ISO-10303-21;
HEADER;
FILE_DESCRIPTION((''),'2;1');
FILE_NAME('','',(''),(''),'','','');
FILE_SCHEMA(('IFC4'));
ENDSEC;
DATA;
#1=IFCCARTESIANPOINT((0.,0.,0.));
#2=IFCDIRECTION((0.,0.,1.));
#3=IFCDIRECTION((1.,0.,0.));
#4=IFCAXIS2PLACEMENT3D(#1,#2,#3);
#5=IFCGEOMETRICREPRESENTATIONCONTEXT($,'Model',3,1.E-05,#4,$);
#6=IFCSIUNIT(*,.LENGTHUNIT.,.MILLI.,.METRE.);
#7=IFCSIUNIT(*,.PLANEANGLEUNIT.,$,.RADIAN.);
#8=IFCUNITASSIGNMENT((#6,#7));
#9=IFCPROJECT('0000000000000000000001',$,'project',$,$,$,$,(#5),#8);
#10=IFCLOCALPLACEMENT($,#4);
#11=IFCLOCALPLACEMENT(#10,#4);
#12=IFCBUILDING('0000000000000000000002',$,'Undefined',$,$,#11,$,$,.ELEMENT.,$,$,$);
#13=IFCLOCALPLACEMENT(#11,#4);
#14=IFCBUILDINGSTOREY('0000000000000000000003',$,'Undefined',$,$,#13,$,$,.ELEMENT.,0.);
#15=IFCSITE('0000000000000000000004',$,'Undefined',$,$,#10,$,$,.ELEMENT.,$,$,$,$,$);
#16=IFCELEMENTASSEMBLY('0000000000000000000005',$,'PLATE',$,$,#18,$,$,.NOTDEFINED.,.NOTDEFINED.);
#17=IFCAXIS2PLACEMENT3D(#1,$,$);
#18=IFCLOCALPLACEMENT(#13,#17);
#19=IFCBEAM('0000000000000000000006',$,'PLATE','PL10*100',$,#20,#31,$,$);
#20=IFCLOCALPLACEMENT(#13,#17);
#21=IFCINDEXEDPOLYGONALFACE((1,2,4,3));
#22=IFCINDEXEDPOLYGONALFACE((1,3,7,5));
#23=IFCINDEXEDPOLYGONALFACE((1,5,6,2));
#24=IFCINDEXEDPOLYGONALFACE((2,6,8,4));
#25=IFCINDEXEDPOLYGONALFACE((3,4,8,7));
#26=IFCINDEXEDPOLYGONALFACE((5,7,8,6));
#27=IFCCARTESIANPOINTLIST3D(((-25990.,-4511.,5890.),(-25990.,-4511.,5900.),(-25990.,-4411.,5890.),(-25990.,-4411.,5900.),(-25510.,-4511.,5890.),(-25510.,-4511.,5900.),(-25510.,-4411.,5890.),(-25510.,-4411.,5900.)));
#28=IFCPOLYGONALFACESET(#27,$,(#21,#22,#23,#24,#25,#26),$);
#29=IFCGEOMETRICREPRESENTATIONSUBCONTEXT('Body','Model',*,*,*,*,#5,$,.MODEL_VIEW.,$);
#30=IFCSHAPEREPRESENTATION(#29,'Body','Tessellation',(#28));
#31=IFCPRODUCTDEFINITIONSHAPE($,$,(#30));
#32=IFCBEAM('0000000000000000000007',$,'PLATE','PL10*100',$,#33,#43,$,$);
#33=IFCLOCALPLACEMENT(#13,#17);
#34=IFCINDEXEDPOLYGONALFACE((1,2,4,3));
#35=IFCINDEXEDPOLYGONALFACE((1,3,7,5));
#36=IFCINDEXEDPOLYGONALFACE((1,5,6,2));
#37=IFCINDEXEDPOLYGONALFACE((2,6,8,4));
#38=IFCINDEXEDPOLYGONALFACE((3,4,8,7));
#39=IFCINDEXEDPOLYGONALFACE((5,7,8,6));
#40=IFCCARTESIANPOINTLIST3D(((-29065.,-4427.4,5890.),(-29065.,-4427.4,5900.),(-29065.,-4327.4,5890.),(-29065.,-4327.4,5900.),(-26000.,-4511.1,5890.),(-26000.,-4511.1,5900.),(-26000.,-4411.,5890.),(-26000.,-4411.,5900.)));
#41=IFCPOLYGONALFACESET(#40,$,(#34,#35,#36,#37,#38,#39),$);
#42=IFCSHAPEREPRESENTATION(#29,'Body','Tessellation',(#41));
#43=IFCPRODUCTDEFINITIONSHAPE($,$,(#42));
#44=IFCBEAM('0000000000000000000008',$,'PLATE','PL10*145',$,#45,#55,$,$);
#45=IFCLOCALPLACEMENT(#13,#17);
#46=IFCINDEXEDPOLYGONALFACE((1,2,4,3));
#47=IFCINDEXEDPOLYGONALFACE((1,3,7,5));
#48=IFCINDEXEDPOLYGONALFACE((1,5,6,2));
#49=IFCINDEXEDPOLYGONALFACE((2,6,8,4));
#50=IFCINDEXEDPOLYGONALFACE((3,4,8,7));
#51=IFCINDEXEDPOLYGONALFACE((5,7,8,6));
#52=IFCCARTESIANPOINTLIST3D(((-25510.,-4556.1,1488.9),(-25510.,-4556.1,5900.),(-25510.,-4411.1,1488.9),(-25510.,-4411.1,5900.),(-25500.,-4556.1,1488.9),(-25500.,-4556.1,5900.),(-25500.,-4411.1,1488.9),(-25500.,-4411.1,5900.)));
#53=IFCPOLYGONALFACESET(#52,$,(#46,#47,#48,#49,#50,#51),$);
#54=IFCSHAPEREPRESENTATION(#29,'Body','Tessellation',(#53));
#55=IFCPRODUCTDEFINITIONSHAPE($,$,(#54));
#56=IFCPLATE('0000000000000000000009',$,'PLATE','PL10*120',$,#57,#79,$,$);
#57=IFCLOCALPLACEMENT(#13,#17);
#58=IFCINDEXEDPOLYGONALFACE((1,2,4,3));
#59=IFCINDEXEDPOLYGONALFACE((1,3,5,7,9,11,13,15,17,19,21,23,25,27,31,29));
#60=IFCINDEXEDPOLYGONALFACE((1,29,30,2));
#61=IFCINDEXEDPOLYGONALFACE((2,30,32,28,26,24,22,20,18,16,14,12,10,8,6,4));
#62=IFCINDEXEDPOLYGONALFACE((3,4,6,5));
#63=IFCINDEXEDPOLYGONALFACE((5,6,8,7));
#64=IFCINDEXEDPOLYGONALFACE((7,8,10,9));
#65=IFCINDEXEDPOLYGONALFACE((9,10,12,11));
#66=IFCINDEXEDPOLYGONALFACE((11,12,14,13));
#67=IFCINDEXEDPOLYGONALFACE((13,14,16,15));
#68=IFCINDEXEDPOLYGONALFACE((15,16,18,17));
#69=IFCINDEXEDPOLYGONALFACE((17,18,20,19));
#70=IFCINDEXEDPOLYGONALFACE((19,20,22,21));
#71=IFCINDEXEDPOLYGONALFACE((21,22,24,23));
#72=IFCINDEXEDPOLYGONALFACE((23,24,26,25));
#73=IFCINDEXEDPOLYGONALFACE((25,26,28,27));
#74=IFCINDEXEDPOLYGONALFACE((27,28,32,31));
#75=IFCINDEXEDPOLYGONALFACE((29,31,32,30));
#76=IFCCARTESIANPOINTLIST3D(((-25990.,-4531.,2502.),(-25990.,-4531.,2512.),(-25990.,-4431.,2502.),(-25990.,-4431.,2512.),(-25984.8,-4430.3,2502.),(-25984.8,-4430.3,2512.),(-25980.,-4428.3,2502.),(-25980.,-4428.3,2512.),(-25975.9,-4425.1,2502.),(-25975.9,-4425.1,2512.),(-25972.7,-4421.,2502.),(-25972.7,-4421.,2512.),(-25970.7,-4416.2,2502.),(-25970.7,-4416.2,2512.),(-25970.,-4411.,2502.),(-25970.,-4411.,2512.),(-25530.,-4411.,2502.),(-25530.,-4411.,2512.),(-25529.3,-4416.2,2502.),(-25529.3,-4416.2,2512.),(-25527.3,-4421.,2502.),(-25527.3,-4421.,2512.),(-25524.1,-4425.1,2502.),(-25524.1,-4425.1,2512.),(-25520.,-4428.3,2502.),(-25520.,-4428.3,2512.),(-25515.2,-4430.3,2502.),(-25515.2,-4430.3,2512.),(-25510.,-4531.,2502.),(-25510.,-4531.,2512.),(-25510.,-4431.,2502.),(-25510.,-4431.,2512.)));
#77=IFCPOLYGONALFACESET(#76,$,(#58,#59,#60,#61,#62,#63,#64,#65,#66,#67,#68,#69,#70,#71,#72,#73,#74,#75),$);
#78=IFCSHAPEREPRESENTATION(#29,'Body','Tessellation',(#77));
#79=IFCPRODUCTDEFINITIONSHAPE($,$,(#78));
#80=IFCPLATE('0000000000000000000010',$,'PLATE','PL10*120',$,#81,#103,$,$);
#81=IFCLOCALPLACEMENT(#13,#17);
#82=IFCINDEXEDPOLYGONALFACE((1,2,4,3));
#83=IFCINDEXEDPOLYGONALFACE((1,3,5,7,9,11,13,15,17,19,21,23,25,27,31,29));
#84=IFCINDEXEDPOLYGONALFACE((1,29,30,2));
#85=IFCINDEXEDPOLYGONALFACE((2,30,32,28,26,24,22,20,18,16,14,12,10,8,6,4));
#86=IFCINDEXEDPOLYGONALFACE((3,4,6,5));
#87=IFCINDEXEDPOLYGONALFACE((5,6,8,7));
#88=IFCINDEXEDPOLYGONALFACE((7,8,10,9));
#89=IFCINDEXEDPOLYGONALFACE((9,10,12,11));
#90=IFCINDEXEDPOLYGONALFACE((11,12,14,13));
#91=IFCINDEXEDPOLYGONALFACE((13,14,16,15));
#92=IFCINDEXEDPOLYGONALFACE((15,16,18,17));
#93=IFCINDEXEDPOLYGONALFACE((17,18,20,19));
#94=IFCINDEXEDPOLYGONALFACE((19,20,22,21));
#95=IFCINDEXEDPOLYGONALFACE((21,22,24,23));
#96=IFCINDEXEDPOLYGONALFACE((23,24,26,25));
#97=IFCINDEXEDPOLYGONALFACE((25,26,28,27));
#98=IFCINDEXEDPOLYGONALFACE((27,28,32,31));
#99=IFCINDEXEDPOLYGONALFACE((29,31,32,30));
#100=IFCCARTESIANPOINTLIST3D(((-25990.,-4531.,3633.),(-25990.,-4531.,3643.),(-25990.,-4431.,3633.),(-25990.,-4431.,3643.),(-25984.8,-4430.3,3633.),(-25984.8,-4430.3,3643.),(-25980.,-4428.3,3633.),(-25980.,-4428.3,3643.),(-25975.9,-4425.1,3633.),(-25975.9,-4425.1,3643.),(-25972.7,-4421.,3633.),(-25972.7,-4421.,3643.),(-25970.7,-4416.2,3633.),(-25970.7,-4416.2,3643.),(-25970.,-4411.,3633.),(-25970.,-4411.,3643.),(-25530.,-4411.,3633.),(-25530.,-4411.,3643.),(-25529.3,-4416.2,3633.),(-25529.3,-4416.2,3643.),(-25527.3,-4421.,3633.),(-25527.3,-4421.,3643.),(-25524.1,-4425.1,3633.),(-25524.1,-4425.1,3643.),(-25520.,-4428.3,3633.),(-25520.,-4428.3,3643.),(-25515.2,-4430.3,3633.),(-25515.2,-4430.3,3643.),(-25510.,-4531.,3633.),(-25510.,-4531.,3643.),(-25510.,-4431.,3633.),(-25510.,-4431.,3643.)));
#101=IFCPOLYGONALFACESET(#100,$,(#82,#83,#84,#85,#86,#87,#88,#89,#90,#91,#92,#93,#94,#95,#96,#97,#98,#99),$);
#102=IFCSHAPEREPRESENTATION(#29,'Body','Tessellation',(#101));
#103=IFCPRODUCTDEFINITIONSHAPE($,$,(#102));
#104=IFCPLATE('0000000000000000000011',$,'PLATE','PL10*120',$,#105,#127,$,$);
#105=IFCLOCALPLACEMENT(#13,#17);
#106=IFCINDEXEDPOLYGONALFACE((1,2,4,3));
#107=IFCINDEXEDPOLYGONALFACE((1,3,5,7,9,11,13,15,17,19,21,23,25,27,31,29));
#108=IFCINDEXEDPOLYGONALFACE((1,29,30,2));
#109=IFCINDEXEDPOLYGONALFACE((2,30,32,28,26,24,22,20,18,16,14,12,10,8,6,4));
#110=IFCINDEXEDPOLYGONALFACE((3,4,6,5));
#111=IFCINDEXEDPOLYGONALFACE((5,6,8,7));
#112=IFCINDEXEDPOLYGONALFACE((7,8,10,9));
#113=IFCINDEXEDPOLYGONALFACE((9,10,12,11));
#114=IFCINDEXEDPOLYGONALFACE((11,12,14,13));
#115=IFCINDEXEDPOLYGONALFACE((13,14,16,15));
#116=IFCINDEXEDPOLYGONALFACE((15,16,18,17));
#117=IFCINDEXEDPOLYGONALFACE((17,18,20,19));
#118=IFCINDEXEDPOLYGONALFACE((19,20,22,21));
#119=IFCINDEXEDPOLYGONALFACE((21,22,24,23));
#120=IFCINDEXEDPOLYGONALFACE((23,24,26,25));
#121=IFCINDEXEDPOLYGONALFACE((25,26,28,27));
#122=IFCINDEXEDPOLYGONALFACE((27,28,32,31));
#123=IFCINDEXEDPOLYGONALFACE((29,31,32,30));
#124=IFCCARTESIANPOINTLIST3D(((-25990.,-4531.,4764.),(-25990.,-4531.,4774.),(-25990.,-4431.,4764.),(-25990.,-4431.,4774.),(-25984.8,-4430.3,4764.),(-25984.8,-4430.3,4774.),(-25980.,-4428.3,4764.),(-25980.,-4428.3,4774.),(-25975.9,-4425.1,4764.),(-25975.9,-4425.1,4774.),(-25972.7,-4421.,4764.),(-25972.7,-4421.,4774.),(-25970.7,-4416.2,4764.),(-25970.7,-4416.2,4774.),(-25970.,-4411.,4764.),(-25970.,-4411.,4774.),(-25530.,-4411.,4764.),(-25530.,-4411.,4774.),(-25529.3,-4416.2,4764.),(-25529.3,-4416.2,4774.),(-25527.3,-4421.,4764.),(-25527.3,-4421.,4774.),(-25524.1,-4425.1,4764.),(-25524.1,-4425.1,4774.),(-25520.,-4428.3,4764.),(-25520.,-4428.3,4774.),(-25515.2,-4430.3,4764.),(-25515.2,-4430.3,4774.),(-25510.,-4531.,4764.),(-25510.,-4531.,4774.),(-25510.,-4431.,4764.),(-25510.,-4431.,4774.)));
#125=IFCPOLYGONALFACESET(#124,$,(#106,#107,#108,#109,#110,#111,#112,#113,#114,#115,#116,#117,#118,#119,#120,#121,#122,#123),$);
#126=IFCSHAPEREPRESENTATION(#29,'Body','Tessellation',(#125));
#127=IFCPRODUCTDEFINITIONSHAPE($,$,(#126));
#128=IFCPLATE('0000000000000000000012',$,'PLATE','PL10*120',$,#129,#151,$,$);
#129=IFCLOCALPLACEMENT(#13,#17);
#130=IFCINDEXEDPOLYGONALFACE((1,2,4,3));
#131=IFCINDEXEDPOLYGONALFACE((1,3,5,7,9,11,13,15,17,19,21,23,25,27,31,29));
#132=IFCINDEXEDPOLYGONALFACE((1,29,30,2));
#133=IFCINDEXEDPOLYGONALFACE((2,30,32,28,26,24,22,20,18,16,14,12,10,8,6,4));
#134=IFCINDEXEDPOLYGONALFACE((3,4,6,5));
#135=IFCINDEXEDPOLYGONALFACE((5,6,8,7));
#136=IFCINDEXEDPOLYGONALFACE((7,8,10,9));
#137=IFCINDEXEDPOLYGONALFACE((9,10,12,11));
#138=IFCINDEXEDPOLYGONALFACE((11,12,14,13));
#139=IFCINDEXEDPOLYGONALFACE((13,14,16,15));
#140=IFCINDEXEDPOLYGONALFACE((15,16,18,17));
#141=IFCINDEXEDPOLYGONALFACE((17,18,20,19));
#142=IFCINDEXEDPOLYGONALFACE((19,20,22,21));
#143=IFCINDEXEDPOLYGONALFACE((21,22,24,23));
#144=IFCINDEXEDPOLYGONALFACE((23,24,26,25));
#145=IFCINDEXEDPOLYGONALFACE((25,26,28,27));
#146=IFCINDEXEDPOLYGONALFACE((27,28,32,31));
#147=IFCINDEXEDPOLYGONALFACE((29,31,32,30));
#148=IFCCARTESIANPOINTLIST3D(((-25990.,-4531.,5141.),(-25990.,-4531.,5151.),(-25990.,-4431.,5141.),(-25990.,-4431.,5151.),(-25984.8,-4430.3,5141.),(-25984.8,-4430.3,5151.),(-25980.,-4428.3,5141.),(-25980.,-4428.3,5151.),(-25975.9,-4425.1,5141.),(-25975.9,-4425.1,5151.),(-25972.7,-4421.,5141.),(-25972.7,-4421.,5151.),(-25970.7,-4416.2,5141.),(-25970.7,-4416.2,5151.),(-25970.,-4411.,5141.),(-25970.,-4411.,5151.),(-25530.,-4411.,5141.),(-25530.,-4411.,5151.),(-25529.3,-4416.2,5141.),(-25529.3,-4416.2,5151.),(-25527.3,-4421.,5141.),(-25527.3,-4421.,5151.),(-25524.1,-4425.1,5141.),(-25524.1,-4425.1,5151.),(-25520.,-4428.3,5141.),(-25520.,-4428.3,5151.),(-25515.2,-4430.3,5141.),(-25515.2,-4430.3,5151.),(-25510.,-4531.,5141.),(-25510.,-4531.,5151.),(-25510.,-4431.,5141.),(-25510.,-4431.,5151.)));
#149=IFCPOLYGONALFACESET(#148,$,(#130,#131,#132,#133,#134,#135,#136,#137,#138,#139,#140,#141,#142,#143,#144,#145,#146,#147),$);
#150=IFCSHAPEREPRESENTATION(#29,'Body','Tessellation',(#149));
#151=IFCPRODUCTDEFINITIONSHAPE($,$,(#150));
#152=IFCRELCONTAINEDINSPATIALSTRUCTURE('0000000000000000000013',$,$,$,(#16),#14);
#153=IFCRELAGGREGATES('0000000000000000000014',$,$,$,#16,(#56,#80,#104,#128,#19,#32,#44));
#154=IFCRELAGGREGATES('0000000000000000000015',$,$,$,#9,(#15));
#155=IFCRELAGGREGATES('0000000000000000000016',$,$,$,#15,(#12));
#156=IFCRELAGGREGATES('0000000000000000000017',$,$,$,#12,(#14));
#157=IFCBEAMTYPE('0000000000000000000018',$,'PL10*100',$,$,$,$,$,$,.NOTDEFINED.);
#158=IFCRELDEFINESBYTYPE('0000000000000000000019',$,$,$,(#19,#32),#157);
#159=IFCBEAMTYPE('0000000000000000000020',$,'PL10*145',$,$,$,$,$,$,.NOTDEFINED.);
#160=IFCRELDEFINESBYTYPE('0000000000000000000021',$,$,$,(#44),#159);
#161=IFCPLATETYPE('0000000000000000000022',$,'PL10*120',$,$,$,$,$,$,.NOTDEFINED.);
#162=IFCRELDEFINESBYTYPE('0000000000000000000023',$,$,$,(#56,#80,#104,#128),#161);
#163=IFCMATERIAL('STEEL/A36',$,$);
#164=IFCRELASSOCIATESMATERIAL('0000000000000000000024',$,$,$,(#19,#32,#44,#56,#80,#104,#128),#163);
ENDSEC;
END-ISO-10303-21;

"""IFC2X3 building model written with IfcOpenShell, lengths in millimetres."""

from ifc_helpers import new_model, si_unit, frame, frame_2d, origin_with_axes, origin_2d_with_axis, place, context, subcontext, project, spatial, polyline, circle_curve, parameter, trimmed, segment, composite_curve, rectangle, outline, extrude, clip, halfspace, material, type_object, element, aggregate, save


model = new_model("IFC2X3")

# Units and contexts
model_context = context("Model", 3, precision=1e-05, world=origin_with_axes())
body_context = subcontext(model_context, "Body", "Model", "MODEL_VIEW")
ifc_project = project(units=[si_unit("LENGTHUNIT", "METRE", prefix="MILLI"), si_unit("PLANEANGLEUNIT", "RADIAN")], contexts=[model_context])

# Site, building, storey
site_placement = place(None, origin_with_axes())
site = spatial("IfcSite", under=ifc_project, at=site_placement, Name="Undefined", CompositionType="ELEMENT")
building_placement = place(site_placement, origin_with_axes())
building = spatial("IfcBuilding", under=site, at=building_placement, Name="Undefined", CompositionType="ELEMENT")
storey_placement = place(building_placement, origin_with_axes())
storey = spatial("IfcBuildingStorey", under=building, at=storey_placement, Name="Undefined", CompositionType="ELEMENT", Elevation=0.0)

# Element assembly, beams, plates
assembly_1_placement = place(storey_placement, origin_with_axes())
assembly_1 = element("IfcElementAssembly", 1, at=assembly_1_placement, inside=storey, Name="PLATE", AssemblyPlace="NOTDEFINED", PredefinedType="NOTDEFINED")
ifc_material_1 = material(Name="STEEL/A36")
beam_type_1 = type_object("IfcBeamType", Name="PL10*100", PredefinedType="NOTDEFINED")
beam_1_placement = place(assembly_1_placement, frame((-25510.0, -4461.0, 5895.0), z_axis=(-0.000007, -1.0, 0.0), x_axis=(-1.0, 0.000007, 0.0)))
beam_1 = element("IfcBeam", 2, at=beam_1_placement, type_object=beam_type_1, material=ifc_material_1, Name="PLATE", Description="PL10*100", context=body_context, shape_type="SweptSolid", body=[
    extrude(rectangle(XDim=10.0, YDim=100.0, at=origin_2d_with_axis()), frame((480.0, 0.0, 0.0), z_axis=(-1.0, 0.0, 0.0), x_axis=(0.0, -1.0, 0.0)), (0.0, 0.0, 1.0), 480.0),
])
beam_2_placement = place(assembly_1_placement, frame((-25998.6, -4461.1, 5895.0), z_axis=(-0.027287, -0.999628, 0.0), x_axis=(-0.999628, 0.027287, 0.0)))
beam_2 = element("IfcBeam", 3, at=beam_2_placement, type_object=beam_type_1, material=ifc_material_1, Name="PLATE", Description="PL10*100", context=body_context, shape_type="Clipping", body=[
    clip(clip(extrude(rectangle(XDim=10.0, YDim=100.0, at=origin_2d_with_axis()), frame((3081.1, 0.0, 0.0), z_axis=(-1.0, 0.0, 0.0), x_axis=(0.0, -1.0, 0.0)), (0.0, 0.0, 1.0), 3081.1), halfspace(frame((2.7, -5.0, -50.0), z_axis=(-0.999628, 0.0, -0.027287), x_axis=(0.0, 1.0, 0.0)), False)), halfspace(frame((3066.4, 5895.0, 40.0), z_axis=(-0.999624, 0.0, -0.027424), x_axis=(0.0, -1.0, 0.0)), True)),
])
beam_type_2 = type_object("IfcBeamType", Name="PL10*145", PredefinedType="NOTDEFINED")
beam_3_placement = place(assembly_1_placement, frame((-25505.0, -4483.6, 5900.0), z_axis=(0.0, -1.0, 0.0), x_axis=(0.0, 0.0, -1.0)))
beam_3 = element("IfcBeam", 4, at=beam_3_placement, type_object=beam_type_2, material=ifc_material_1, Name="PLATE", Description="PL10*145", context=body_context, shape_type="SweptSolid", body=[
    extrude(rectangle(XDim=10.0, YDim=145.0, at=origin_2d_with_axis()), frame((4411.1, 0.0, 0.0), z_axis=(-1.0, 0.0, 0.0), x_axis=(0.0, -1.0, 0.0)), (0.0, 0.0, 1.0), 4411.1),
])
plate_type_1 = type_object("IfcPlateType", Name="PL10*120", PredefinedType="NOTDEFINED")
plate_1_placement = place(assembly_1_placement, frame((-25510.0, -4531.0, 2507.0), z_axis=(0.0, 0.0, -1.0), x_axis=(-1.0, 0.0, 0.0)))
plate_1 = element("IfcPlate", 5, at=plate_1_placement, type_object=plate_type_1, material=ifc_material_1, Name="PLATE", Description="PL10*120", context=body_context, shape_type="SweptSolid", body=[
    extrude(outline(composite_curve([segment(polyline([(0.0, 0.0), (480.0, 0.0), (480.0, 100.0)]), True, "CONTINUOUS"), segment(trimmed(circle_curve(frame_2d((480.0, 120.0), x_axis=(-0.000015, -1.0)), 20.0), [parameter(0.0)], [parameter(4.712402)], False, "PARAMETER"), True, "CONTINUOUS"), segment(polyline([(460.0, 120.0), (20.0, 120.0)]), True, "CONTINUOUS"), segment(trimmed(circle_curve(frame_2d((0.0, 120.0), x_axis=(1.0, -0.000002)), 20.0), [parameter(0.0)], [parameter(4.712393)], False, "PARAMETER"), True, "CONTINUOUS"), segment(polyline([(0.0, 100.0), (0.0, 0.0)]), True, "CONTINUOUS")], self_intersect=True)), frame((0.0, 0.0, -5.0), z_axis=(0.0, 0.0, 1.0), x_axis=(1.0, 0.0, 0.0)), (0.0, 0.0, 1.0), 10.0),
])
plate_2_placement = place(assembly_1_placement, frame((-25510.0, -4531.0, 3638.0), z_axis=(0.0, 0.0, -1.0), x_axis=(-1.0, 0.0, 0.0)))
plate_2 = element("IfcPlate", 6, at=plate_2_placement, type_object=plate_type_1, material=ifc_material_1, Name="PLATE", Description="PL10*120", context=body_context, shape_type="SweptSolid", body=[
    extrude(outline(composite_curve([segment(polyline([(0.0, 0.0), (480.0, 0.0), (480.0, 100.0)]), True, "CONTINUOUS"), segment(trimmed(circle_curve(frame_2d((480.0, 120.0), x_axis=(-0.000015, -1.0)), 20.0), [parameter(0.0)], [parameter(4.712402)], False, "PARAMETER"), True, "CONTINUOUS"), segment(polyline([(460.0, 120.0), (20.0, 120.0)]), True, "CONTINUOUS"), segment(trimmed(circle_curve(frame_2d((0.0, 120.0), x_axis=(1.0, -0.000002)), 20.0), [parameter(0.0)], [parameter(4.712393)], False, "PARAMETER"), True, "CONTINUOUS"), segment(polyline([(0.0, 100.0), (0.0, 0.0)]), True, "CONTINUOUS")], self_intersect=True)), frame((0.0, 0.0, -5.0), z_axis=(0.0, 0.0, 1.0), x_axis=(1.0, 0.0, 0.0)), (0.0, 0.0, 1.0), 10.0),
])
plate_3_placement = place(assembly_1_placement, frame((-25510.0, -4531.0, 4769.0), z_axis=(0.0, 0.0, -1.0), x_axis=(-1.0, 0.0, 0.0)))
plate_3 = element("IfcPlate", 7, at=plate_3_placement, type_object=plate_type_1, material=ifc_material_1, Name="PLATE", Description="PL10*120", context=body_context, shape_type="SweptSolid", body=[
    extrude(outline(composite_curve([segment(polyline([(0.0, 0.0), (480.0, 0.0), (480.0, 100.0)]), True, "CONTINUOUS"), segment(trimmed(circle_curve(frame_2d((480.0, 120.0), x_axis=(-0.000015, -1.0)), 20.0), [parameter(0.0)], [parameter(4.712402)], False, "PARAMETER"), True, "CONTINUOUS"), segment(polyline([(460.0, 120.0), (20.0, 120.0)]), True, "CONTINUOUS"), segment(trimmed(circle_curve(frame_2d((0.0, 120.0), x_axis=(1.0, -0.000002)), 20.0), [parameter(0.0)], [parameter(4.712393)], False, "PARAMETER"), True, "CONTINUOUS"), segment(polyline([(0.0, 100.0), (0.0, 0.0)]), True, "CONTINUOUS")], self_intersect=True)), frame((0.0, 0.0, -5.0), z_axis=(0.0, 0.0, 1.0), x_axis=(1.0, 0.0, 0.0)), (0.0, 0.0, 1.0), 10.0),
])
plate_4_placement = place(assembly_1_placement, frame((-25510.0, -4531.0, 5146.0), z_axis=(0.0, 0.0, -1.0), x_axis=(-1.0, 0.0, 0.0)))
plate_4 = element("IfcPlate", 8, at=plate_4_placement, type_object=plate_type_1, material=ifc_material_1, Name="PLATE", Description="PL10*120", context=body_context, shape_type="SweptSolid", body=[
    extrude(outline(composite_curve([segment(polyline([(0.0, 0.0), (480.0, 0.0), (480.0, 100.0)]), True, "CONTINUOUS"), segment(trimmed(circle_curve(frame_2d((480.0, 120.0), x_axis=(-0.000015, -1.0)), 20.0), [parameter(0.0)], [parameter(4.712402)], False, "PARAMETER"), True, "CONTINUOUS"), segment(polyline([(460.0, 120.0), (20.0, 120.0)]), True, "CONTINUOUS"), segment(trimmed(circle_curve(frame_2d((0.0, 120.0), x_axis=(1.0, -0.000002)), 20.0), [parameter(0.0)], [parameter(4.712393)], False, "PARAMETER"), True, "CONTINUOUS"), segment(polyline([(0.0, 100.0), (0.0, 0.0)]), True, "CONTINUOUS")], self_intersect=True)), frame((0.0, 0.0, -5.0), z_axis=(0.0, 0.0, 1.0), x_axis=(1.0, 0.0, 0.0)), (0.0, 0.0, 1.0), 10.0),
])

aggregate(assembly_1, [plate_1, plate_2, plate_3, plate_4, beam_1, beam_2, beam_3])

save(model, "model.ifc")
